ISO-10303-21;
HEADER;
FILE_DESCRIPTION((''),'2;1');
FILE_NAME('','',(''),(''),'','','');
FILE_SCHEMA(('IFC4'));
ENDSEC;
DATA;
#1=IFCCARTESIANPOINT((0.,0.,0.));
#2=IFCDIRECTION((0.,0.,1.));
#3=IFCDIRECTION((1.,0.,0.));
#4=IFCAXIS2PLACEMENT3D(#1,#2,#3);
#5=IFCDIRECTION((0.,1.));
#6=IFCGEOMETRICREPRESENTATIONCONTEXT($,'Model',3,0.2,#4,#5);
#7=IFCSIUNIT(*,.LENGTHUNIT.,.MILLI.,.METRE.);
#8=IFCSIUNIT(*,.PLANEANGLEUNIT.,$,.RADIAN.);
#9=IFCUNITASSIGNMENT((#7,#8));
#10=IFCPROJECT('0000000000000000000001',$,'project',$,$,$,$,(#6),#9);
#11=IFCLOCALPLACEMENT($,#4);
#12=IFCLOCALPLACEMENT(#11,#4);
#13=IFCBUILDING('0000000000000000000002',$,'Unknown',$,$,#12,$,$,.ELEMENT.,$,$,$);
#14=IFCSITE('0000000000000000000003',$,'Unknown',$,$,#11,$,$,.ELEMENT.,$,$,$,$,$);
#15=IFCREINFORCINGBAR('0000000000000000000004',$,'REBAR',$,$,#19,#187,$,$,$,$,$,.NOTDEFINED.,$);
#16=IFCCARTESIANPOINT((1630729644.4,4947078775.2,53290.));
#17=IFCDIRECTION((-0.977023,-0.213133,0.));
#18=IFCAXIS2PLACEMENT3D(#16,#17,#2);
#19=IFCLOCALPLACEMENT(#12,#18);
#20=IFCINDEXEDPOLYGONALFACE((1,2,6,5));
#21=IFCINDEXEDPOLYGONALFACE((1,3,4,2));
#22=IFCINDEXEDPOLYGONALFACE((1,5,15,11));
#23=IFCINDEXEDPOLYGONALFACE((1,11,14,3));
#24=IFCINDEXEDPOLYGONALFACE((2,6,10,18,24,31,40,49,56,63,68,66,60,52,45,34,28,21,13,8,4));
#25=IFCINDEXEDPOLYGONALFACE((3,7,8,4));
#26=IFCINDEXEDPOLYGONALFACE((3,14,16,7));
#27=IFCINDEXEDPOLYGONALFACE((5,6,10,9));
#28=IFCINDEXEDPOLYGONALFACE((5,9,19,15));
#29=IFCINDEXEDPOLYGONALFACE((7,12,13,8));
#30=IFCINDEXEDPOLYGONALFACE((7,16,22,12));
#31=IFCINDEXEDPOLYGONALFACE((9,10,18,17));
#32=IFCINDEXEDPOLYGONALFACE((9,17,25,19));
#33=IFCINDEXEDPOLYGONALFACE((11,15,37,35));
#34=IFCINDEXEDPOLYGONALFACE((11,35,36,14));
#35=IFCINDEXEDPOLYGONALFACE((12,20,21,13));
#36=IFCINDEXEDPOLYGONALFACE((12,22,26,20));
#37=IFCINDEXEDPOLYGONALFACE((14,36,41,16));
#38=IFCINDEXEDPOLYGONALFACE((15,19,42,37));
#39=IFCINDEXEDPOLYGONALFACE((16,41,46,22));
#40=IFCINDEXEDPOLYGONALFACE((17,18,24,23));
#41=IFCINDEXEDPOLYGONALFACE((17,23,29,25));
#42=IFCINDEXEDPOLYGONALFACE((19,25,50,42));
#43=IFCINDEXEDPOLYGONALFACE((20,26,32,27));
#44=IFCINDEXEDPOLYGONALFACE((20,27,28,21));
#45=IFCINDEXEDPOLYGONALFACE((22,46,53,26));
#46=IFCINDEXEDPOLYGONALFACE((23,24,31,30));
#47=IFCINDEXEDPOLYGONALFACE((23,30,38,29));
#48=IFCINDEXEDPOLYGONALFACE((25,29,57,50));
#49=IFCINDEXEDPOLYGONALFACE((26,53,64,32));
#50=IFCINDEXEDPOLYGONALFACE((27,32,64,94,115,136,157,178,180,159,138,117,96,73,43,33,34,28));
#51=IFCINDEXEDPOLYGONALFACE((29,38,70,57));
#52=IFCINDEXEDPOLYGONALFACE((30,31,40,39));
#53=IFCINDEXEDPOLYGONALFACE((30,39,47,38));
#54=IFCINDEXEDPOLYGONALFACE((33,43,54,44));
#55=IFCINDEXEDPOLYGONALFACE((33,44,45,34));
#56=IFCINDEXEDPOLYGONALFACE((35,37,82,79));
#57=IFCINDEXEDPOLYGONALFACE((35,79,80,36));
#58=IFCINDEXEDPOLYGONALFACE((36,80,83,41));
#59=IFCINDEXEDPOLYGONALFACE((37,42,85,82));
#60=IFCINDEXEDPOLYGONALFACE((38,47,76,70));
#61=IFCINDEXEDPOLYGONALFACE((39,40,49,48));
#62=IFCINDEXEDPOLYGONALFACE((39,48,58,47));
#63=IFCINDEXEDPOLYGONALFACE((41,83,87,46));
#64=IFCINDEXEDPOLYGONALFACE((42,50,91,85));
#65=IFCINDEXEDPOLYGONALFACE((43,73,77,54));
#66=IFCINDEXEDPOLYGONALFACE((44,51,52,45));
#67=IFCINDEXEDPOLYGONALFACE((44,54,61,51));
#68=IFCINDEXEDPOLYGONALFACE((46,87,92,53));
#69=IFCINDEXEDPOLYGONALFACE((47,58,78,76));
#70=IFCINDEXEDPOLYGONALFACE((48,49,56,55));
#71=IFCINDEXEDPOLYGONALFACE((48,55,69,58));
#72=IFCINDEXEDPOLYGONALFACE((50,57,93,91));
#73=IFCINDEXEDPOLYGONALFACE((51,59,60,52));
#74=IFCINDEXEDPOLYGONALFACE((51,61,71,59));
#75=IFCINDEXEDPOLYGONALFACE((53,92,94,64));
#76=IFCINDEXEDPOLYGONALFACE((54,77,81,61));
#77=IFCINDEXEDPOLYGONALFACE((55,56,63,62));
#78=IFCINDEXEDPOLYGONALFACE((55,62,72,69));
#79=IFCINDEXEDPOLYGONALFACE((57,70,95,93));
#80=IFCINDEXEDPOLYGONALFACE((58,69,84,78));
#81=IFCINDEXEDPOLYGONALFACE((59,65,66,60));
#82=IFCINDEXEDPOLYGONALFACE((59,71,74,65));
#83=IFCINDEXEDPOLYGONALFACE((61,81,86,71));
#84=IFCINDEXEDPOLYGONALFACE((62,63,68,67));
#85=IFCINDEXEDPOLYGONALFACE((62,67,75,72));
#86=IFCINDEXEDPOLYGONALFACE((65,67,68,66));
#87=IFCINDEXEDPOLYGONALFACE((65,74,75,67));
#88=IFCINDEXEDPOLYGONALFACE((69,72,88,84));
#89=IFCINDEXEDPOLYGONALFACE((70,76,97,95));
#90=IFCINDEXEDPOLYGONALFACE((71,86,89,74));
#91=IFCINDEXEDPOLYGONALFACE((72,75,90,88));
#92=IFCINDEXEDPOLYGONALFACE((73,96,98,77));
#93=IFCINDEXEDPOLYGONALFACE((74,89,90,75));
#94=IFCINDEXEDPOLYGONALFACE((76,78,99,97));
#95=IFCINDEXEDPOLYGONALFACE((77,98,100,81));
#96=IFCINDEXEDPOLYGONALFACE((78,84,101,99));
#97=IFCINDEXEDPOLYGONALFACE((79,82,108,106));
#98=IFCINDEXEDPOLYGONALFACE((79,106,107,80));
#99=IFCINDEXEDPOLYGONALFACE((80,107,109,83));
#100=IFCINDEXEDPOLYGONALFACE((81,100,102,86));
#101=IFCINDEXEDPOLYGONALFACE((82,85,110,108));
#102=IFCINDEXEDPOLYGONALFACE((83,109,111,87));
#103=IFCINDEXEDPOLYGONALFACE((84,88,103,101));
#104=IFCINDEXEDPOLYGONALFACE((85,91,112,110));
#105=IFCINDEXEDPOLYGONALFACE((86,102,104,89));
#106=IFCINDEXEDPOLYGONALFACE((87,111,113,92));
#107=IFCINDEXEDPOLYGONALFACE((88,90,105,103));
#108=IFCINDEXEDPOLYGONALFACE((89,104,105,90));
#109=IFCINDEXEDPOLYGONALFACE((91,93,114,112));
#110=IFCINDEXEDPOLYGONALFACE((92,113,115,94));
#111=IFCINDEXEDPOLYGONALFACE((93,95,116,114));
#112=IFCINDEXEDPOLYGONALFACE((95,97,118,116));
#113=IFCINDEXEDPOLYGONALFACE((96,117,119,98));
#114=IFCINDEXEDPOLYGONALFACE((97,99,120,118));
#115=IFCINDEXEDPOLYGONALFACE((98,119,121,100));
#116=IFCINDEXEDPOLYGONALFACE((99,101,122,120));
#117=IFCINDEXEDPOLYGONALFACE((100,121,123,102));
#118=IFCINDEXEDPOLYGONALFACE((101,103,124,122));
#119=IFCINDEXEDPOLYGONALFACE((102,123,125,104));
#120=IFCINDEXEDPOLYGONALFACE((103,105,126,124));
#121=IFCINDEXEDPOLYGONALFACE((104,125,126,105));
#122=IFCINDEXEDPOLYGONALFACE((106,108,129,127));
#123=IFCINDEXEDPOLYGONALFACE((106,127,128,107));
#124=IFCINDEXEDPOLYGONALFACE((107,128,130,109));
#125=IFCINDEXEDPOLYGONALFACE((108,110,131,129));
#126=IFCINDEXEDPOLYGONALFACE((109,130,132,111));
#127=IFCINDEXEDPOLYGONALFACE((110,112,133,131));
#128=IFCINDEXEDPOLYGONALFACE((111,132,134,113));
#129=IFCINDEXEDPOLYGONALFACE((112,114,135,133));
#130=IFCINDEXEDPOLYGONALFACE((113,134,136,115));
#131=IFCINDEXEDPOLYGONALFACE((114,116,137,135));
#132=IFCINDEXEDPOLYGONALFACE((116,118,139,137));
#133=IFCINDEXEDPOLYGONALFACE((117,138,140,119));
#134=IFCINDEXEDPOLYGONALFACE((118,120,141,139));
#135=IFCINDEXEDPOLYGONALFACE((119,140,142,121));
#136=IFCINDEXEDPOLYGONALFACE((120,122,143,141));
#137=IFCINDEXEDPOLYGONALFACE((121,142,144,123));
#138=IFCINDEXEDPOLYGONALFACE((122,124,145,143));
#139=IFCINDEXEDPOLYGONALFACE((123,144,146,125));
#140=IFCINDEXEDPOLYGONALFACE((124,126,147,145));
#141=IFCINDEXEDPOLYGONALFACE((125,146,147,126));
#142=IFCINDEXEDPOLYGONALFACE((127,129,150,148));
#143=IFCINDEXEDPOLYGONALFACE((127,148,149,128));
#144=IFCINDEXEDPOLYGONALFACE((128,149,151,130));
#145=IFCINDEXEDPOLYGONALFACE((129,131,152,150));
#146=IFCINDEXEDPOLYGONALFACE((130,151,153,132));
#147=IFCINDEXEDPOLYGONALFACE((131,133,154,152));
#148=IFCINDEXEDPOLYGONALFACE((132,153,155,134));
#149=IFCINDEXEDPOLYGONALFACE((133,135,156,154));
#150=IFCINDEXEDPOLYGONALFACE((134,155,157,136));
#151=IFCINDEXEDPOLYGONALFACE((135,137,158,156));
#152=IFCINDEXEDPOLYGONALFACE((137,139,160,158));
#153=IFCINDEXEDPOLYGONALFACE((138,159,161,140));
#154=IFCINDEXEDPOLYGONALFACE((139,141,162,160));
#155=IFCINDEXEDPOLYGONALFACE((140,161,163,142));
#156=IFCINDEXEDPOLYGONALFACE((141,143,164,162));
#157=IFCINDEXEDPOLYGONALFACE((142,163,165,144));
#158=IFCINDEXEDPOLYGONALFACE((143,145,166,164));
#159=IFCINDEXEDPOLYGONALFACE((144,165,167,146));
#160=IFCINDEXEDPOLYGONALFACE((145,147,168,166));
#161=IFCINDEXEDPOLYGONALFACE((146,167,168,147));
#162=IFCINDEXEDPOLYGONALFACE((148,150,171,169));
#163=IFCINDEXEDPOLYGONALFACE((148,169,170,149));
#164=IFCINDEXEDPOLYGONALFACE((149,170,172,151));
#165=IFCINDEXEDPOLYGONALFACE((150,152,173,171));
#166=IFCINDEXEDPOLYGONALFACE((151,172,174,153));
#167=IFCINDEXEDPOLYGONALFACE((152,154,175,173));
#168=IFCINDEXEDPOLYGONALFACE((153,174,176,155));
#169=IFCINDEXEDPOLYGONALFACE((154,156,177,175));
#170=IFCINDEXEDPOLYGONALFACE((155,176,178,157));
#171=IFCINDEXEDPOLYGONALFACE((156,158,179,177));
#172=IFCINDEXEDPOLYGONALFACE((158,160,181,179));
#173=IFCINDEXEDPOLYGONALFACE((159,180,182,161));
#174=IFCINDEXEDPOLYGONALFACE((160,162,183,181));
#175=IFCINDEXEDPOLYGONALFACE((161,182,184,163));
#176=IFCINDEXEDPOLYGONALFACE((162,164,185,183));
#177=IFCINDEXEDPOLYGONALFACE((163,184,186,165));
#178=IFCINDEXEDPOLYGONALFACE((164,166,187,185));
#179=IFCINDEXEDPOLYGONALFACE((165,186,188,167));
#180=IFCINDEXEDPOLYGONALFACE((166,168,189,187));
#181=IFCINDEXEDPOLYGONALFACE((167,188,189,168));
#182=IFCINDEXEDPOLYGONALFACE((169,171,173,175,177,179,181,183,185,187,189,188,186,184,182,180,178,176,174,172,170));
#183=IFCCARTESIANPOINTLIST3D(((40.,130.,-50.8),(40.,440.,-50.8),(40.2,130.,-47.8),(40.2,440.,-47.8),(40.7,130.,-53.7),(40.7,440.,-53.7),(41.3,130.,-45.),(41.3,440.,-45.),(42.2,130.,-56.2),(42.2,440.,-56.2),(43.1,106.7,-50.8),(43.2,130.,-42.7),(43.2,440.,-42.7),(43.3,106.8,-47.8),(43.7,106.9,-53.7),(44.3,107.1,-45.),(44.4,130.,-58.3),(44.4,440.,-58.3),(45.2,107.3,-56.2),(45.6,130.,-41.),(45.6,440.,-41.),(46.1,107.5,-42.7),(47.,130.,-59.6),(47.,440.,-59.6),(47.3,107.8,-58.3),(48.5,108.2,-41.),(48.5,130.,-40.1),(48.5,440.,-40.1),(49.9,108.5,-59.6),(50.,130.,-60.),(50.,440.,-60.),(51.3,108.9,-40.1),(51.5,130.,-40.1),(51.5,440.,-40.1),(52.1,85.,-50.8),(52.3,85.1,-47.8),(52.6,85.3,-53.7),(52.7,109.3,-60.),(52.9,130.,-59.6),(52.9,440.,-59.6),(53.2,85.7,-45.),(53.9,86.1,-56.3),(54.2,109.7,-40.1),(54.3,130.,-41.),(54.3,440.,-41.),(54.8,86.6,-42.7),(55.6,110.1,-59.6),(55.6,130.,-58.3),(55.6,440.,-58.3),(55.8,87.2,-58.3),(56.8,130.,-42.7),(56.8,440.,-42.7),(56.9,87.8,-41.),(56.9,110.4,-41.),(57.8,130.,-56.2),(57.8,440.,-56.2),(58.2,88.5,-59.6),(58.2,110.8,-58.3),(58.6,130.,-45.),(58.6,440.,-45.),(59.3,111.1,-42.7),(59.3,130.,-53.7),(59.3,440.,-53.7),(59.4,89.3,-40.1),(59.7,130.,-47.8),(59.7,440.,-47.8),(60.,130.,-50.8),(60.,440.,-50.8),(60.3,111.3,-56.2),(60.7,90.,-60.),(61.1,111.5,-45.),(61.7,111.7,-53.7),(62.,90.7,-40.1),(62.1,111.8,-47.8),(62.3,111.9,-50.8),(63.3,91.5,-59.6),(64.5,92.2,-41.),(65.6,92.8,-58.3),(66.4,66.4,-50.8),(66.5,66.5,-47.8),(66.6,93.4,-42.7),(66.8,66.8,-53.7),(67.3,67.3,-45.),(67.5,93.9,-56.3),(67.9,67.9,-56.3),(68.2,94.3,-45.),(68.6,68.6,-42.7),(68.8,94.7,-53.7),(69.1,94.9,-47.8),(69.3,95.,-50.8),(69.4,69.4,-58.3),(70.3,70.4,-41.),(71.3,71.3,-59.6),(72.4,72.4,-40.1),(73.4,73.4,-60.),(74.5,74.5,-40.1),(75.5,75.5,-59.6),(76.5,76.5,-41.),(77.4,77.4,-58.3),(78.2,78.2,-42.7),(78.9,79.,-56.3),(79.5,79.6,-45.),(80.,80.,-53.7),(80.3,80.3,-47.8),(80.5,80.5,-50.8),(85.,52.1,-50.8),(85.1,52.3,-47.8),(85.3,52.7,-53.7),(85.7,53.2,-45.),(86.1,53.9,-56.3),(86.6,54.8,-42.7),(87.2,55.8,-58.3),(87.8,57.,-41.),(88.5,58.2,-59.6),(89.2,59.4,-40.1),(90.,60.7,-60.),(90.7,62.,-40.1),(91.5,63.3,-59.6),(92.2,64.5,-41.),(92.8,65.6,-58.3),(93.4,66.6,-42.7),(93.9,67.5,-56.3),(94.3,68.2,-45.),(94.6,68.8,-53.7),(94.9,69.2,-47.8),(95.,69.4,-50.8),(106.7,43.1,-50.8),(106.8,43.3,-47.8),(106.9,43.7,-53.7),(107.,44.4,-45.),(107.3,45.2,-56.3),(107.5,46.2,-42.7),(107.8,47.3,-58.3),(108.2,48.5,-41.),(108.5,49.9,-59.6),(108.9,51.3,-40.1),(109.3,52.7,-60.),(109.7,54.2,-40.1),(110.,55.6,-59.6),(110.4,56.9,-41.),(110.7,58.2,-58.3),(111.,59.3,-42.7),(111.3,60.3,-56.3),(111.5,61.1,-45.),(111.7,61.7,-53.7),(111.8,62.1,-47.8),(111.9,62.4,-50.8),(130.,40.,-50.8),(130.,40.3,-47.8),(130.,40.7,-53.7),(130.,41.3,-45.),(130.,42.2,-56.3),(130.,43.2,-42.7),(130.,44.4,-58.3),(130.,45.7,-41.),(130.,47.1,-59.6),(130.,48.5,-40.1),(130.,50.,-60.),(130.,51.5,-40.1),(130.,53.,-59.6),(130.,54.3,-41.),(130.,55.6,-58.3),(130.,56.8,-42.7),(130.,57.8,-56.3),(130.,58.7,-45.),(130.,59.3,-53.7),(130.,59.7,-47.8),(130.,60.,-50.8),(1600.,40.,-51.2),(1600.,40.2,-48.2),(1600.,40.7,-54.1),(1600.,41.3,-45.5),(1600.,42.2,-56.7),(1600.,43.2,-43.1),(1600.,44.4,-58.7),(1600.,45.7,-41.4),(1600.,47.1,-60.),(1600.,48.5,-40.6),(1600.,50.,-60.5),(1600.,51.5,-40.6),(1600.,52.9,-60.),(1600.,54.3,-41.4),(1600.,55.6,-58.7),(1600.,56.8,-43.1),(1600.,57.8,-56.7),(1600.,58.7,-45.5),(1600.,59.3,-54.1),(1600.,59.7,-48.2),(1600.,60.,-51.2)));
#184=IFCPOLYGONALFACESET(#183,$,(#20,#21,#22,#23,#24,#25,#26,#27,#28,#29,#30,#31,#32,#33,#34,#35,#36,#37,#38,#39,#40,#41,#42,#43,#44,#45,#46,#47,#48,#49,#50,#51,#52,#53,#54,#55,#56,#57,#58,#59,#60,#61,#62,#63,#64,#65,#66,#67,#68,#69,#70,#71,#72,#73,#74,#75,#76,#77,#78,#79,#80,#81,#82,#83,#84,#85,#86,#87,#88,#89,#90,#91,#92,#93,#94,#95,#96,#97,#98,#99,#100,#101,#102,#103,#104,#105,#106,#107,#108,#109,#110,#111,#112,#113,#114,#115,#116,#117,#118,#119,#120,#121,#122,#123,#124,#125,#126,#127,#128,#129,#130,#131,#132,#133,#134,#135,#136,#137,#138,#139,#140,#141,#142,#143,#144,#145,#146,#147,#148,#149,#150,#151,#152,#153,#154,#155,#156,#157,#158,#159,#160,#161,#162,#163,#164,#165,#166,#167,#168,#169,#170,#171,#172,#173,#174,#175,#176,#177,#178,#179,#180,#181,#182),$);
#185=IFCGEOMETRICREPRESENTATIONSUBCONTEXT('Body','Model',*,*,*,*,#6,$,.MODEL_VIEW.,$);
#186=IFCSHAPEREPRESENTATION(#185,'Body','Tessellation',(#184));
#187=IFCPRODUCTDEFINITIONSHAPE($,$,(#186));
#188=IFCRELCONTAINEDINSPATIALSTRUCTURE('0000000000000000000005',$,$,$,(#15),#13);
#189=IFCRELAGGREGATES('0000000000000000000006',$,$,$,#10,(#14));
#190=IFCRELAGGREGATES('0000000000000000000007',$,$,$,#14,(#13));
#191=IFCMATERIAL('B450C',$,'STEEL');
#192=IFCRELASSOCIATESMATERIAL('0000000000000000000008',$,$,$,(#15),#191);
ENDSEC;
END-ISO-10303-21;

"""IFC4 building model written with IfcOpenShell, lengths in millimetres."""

from ifc_helpers import new_model, entity, si_unit, direction, frame, origin_with_axes, place, context, subcontext, project, spatial, material, element, save


model = new_model("IFC4")

# Units and contexts
model_context = context("Model", 3, precision=0.2, world=origin_with_axes(), true_north=direction((0.0, 1.0)))
body_context = subcontext(model_context, "Body", "Model", "MODEL_VIEW")
ifc_project = project(units=[si_unit("LENGTHUNIT", "METRE", prefix="MILLI"), si_unit("PLANEANGLEUNIT", "RADIAN")], contexts=[model_context])

# Site, building
site_placement = place(None, origin_with_axes())
site = spatial("IfcSite", under=ifc_project, at=site_placement, Name="Unknown", CompositionType="ELEMENT")
building_placement = place(site_placement, origin_with_axes())
building = spatial("IfcBuilding", under=site, at=building_placement, Name="Unknown", CompositionType="ELEMENT")

# Reinforcing bar
ifc_material = material(Name="B450C", Category="STEEL")
reinforcing_bar_1_placement = place(building_placement, frame((1630729644.4, 4947078775.2, 53290.0), z_axis=(-0.977023, -0.213133, 0.0), x_axis=(0.0, 0.0, 1.0)))
element("IfcReinforcingBar", 1, at=reinforcing_bar_1_placement, inside=building, material=ifc_material, Name="REBAR", PredefinedType="NOTDEFINED", context=body_context, shape_type="AdvancedSweptSolid", body=[
    entity("IfcSweptDiskSolid", entity("IfcIndexedPolyCurve", entity("IfcCartesianPointList3D", [[50.0, 440.0, -50.0], [50.0, 130.0, -50.0], [73.4, 73.4, -50.0], [130.0, 50.0, -50.0], [1600.0, 50.0, -50.5]]), [entity("IfcLineIndex", [1, 2]), entity("IfcArcIndex", [2, 3, 4]), entity("IfcLineIndex", [4, 5])]), 10.0),
])

save(model, "model.ifc")
